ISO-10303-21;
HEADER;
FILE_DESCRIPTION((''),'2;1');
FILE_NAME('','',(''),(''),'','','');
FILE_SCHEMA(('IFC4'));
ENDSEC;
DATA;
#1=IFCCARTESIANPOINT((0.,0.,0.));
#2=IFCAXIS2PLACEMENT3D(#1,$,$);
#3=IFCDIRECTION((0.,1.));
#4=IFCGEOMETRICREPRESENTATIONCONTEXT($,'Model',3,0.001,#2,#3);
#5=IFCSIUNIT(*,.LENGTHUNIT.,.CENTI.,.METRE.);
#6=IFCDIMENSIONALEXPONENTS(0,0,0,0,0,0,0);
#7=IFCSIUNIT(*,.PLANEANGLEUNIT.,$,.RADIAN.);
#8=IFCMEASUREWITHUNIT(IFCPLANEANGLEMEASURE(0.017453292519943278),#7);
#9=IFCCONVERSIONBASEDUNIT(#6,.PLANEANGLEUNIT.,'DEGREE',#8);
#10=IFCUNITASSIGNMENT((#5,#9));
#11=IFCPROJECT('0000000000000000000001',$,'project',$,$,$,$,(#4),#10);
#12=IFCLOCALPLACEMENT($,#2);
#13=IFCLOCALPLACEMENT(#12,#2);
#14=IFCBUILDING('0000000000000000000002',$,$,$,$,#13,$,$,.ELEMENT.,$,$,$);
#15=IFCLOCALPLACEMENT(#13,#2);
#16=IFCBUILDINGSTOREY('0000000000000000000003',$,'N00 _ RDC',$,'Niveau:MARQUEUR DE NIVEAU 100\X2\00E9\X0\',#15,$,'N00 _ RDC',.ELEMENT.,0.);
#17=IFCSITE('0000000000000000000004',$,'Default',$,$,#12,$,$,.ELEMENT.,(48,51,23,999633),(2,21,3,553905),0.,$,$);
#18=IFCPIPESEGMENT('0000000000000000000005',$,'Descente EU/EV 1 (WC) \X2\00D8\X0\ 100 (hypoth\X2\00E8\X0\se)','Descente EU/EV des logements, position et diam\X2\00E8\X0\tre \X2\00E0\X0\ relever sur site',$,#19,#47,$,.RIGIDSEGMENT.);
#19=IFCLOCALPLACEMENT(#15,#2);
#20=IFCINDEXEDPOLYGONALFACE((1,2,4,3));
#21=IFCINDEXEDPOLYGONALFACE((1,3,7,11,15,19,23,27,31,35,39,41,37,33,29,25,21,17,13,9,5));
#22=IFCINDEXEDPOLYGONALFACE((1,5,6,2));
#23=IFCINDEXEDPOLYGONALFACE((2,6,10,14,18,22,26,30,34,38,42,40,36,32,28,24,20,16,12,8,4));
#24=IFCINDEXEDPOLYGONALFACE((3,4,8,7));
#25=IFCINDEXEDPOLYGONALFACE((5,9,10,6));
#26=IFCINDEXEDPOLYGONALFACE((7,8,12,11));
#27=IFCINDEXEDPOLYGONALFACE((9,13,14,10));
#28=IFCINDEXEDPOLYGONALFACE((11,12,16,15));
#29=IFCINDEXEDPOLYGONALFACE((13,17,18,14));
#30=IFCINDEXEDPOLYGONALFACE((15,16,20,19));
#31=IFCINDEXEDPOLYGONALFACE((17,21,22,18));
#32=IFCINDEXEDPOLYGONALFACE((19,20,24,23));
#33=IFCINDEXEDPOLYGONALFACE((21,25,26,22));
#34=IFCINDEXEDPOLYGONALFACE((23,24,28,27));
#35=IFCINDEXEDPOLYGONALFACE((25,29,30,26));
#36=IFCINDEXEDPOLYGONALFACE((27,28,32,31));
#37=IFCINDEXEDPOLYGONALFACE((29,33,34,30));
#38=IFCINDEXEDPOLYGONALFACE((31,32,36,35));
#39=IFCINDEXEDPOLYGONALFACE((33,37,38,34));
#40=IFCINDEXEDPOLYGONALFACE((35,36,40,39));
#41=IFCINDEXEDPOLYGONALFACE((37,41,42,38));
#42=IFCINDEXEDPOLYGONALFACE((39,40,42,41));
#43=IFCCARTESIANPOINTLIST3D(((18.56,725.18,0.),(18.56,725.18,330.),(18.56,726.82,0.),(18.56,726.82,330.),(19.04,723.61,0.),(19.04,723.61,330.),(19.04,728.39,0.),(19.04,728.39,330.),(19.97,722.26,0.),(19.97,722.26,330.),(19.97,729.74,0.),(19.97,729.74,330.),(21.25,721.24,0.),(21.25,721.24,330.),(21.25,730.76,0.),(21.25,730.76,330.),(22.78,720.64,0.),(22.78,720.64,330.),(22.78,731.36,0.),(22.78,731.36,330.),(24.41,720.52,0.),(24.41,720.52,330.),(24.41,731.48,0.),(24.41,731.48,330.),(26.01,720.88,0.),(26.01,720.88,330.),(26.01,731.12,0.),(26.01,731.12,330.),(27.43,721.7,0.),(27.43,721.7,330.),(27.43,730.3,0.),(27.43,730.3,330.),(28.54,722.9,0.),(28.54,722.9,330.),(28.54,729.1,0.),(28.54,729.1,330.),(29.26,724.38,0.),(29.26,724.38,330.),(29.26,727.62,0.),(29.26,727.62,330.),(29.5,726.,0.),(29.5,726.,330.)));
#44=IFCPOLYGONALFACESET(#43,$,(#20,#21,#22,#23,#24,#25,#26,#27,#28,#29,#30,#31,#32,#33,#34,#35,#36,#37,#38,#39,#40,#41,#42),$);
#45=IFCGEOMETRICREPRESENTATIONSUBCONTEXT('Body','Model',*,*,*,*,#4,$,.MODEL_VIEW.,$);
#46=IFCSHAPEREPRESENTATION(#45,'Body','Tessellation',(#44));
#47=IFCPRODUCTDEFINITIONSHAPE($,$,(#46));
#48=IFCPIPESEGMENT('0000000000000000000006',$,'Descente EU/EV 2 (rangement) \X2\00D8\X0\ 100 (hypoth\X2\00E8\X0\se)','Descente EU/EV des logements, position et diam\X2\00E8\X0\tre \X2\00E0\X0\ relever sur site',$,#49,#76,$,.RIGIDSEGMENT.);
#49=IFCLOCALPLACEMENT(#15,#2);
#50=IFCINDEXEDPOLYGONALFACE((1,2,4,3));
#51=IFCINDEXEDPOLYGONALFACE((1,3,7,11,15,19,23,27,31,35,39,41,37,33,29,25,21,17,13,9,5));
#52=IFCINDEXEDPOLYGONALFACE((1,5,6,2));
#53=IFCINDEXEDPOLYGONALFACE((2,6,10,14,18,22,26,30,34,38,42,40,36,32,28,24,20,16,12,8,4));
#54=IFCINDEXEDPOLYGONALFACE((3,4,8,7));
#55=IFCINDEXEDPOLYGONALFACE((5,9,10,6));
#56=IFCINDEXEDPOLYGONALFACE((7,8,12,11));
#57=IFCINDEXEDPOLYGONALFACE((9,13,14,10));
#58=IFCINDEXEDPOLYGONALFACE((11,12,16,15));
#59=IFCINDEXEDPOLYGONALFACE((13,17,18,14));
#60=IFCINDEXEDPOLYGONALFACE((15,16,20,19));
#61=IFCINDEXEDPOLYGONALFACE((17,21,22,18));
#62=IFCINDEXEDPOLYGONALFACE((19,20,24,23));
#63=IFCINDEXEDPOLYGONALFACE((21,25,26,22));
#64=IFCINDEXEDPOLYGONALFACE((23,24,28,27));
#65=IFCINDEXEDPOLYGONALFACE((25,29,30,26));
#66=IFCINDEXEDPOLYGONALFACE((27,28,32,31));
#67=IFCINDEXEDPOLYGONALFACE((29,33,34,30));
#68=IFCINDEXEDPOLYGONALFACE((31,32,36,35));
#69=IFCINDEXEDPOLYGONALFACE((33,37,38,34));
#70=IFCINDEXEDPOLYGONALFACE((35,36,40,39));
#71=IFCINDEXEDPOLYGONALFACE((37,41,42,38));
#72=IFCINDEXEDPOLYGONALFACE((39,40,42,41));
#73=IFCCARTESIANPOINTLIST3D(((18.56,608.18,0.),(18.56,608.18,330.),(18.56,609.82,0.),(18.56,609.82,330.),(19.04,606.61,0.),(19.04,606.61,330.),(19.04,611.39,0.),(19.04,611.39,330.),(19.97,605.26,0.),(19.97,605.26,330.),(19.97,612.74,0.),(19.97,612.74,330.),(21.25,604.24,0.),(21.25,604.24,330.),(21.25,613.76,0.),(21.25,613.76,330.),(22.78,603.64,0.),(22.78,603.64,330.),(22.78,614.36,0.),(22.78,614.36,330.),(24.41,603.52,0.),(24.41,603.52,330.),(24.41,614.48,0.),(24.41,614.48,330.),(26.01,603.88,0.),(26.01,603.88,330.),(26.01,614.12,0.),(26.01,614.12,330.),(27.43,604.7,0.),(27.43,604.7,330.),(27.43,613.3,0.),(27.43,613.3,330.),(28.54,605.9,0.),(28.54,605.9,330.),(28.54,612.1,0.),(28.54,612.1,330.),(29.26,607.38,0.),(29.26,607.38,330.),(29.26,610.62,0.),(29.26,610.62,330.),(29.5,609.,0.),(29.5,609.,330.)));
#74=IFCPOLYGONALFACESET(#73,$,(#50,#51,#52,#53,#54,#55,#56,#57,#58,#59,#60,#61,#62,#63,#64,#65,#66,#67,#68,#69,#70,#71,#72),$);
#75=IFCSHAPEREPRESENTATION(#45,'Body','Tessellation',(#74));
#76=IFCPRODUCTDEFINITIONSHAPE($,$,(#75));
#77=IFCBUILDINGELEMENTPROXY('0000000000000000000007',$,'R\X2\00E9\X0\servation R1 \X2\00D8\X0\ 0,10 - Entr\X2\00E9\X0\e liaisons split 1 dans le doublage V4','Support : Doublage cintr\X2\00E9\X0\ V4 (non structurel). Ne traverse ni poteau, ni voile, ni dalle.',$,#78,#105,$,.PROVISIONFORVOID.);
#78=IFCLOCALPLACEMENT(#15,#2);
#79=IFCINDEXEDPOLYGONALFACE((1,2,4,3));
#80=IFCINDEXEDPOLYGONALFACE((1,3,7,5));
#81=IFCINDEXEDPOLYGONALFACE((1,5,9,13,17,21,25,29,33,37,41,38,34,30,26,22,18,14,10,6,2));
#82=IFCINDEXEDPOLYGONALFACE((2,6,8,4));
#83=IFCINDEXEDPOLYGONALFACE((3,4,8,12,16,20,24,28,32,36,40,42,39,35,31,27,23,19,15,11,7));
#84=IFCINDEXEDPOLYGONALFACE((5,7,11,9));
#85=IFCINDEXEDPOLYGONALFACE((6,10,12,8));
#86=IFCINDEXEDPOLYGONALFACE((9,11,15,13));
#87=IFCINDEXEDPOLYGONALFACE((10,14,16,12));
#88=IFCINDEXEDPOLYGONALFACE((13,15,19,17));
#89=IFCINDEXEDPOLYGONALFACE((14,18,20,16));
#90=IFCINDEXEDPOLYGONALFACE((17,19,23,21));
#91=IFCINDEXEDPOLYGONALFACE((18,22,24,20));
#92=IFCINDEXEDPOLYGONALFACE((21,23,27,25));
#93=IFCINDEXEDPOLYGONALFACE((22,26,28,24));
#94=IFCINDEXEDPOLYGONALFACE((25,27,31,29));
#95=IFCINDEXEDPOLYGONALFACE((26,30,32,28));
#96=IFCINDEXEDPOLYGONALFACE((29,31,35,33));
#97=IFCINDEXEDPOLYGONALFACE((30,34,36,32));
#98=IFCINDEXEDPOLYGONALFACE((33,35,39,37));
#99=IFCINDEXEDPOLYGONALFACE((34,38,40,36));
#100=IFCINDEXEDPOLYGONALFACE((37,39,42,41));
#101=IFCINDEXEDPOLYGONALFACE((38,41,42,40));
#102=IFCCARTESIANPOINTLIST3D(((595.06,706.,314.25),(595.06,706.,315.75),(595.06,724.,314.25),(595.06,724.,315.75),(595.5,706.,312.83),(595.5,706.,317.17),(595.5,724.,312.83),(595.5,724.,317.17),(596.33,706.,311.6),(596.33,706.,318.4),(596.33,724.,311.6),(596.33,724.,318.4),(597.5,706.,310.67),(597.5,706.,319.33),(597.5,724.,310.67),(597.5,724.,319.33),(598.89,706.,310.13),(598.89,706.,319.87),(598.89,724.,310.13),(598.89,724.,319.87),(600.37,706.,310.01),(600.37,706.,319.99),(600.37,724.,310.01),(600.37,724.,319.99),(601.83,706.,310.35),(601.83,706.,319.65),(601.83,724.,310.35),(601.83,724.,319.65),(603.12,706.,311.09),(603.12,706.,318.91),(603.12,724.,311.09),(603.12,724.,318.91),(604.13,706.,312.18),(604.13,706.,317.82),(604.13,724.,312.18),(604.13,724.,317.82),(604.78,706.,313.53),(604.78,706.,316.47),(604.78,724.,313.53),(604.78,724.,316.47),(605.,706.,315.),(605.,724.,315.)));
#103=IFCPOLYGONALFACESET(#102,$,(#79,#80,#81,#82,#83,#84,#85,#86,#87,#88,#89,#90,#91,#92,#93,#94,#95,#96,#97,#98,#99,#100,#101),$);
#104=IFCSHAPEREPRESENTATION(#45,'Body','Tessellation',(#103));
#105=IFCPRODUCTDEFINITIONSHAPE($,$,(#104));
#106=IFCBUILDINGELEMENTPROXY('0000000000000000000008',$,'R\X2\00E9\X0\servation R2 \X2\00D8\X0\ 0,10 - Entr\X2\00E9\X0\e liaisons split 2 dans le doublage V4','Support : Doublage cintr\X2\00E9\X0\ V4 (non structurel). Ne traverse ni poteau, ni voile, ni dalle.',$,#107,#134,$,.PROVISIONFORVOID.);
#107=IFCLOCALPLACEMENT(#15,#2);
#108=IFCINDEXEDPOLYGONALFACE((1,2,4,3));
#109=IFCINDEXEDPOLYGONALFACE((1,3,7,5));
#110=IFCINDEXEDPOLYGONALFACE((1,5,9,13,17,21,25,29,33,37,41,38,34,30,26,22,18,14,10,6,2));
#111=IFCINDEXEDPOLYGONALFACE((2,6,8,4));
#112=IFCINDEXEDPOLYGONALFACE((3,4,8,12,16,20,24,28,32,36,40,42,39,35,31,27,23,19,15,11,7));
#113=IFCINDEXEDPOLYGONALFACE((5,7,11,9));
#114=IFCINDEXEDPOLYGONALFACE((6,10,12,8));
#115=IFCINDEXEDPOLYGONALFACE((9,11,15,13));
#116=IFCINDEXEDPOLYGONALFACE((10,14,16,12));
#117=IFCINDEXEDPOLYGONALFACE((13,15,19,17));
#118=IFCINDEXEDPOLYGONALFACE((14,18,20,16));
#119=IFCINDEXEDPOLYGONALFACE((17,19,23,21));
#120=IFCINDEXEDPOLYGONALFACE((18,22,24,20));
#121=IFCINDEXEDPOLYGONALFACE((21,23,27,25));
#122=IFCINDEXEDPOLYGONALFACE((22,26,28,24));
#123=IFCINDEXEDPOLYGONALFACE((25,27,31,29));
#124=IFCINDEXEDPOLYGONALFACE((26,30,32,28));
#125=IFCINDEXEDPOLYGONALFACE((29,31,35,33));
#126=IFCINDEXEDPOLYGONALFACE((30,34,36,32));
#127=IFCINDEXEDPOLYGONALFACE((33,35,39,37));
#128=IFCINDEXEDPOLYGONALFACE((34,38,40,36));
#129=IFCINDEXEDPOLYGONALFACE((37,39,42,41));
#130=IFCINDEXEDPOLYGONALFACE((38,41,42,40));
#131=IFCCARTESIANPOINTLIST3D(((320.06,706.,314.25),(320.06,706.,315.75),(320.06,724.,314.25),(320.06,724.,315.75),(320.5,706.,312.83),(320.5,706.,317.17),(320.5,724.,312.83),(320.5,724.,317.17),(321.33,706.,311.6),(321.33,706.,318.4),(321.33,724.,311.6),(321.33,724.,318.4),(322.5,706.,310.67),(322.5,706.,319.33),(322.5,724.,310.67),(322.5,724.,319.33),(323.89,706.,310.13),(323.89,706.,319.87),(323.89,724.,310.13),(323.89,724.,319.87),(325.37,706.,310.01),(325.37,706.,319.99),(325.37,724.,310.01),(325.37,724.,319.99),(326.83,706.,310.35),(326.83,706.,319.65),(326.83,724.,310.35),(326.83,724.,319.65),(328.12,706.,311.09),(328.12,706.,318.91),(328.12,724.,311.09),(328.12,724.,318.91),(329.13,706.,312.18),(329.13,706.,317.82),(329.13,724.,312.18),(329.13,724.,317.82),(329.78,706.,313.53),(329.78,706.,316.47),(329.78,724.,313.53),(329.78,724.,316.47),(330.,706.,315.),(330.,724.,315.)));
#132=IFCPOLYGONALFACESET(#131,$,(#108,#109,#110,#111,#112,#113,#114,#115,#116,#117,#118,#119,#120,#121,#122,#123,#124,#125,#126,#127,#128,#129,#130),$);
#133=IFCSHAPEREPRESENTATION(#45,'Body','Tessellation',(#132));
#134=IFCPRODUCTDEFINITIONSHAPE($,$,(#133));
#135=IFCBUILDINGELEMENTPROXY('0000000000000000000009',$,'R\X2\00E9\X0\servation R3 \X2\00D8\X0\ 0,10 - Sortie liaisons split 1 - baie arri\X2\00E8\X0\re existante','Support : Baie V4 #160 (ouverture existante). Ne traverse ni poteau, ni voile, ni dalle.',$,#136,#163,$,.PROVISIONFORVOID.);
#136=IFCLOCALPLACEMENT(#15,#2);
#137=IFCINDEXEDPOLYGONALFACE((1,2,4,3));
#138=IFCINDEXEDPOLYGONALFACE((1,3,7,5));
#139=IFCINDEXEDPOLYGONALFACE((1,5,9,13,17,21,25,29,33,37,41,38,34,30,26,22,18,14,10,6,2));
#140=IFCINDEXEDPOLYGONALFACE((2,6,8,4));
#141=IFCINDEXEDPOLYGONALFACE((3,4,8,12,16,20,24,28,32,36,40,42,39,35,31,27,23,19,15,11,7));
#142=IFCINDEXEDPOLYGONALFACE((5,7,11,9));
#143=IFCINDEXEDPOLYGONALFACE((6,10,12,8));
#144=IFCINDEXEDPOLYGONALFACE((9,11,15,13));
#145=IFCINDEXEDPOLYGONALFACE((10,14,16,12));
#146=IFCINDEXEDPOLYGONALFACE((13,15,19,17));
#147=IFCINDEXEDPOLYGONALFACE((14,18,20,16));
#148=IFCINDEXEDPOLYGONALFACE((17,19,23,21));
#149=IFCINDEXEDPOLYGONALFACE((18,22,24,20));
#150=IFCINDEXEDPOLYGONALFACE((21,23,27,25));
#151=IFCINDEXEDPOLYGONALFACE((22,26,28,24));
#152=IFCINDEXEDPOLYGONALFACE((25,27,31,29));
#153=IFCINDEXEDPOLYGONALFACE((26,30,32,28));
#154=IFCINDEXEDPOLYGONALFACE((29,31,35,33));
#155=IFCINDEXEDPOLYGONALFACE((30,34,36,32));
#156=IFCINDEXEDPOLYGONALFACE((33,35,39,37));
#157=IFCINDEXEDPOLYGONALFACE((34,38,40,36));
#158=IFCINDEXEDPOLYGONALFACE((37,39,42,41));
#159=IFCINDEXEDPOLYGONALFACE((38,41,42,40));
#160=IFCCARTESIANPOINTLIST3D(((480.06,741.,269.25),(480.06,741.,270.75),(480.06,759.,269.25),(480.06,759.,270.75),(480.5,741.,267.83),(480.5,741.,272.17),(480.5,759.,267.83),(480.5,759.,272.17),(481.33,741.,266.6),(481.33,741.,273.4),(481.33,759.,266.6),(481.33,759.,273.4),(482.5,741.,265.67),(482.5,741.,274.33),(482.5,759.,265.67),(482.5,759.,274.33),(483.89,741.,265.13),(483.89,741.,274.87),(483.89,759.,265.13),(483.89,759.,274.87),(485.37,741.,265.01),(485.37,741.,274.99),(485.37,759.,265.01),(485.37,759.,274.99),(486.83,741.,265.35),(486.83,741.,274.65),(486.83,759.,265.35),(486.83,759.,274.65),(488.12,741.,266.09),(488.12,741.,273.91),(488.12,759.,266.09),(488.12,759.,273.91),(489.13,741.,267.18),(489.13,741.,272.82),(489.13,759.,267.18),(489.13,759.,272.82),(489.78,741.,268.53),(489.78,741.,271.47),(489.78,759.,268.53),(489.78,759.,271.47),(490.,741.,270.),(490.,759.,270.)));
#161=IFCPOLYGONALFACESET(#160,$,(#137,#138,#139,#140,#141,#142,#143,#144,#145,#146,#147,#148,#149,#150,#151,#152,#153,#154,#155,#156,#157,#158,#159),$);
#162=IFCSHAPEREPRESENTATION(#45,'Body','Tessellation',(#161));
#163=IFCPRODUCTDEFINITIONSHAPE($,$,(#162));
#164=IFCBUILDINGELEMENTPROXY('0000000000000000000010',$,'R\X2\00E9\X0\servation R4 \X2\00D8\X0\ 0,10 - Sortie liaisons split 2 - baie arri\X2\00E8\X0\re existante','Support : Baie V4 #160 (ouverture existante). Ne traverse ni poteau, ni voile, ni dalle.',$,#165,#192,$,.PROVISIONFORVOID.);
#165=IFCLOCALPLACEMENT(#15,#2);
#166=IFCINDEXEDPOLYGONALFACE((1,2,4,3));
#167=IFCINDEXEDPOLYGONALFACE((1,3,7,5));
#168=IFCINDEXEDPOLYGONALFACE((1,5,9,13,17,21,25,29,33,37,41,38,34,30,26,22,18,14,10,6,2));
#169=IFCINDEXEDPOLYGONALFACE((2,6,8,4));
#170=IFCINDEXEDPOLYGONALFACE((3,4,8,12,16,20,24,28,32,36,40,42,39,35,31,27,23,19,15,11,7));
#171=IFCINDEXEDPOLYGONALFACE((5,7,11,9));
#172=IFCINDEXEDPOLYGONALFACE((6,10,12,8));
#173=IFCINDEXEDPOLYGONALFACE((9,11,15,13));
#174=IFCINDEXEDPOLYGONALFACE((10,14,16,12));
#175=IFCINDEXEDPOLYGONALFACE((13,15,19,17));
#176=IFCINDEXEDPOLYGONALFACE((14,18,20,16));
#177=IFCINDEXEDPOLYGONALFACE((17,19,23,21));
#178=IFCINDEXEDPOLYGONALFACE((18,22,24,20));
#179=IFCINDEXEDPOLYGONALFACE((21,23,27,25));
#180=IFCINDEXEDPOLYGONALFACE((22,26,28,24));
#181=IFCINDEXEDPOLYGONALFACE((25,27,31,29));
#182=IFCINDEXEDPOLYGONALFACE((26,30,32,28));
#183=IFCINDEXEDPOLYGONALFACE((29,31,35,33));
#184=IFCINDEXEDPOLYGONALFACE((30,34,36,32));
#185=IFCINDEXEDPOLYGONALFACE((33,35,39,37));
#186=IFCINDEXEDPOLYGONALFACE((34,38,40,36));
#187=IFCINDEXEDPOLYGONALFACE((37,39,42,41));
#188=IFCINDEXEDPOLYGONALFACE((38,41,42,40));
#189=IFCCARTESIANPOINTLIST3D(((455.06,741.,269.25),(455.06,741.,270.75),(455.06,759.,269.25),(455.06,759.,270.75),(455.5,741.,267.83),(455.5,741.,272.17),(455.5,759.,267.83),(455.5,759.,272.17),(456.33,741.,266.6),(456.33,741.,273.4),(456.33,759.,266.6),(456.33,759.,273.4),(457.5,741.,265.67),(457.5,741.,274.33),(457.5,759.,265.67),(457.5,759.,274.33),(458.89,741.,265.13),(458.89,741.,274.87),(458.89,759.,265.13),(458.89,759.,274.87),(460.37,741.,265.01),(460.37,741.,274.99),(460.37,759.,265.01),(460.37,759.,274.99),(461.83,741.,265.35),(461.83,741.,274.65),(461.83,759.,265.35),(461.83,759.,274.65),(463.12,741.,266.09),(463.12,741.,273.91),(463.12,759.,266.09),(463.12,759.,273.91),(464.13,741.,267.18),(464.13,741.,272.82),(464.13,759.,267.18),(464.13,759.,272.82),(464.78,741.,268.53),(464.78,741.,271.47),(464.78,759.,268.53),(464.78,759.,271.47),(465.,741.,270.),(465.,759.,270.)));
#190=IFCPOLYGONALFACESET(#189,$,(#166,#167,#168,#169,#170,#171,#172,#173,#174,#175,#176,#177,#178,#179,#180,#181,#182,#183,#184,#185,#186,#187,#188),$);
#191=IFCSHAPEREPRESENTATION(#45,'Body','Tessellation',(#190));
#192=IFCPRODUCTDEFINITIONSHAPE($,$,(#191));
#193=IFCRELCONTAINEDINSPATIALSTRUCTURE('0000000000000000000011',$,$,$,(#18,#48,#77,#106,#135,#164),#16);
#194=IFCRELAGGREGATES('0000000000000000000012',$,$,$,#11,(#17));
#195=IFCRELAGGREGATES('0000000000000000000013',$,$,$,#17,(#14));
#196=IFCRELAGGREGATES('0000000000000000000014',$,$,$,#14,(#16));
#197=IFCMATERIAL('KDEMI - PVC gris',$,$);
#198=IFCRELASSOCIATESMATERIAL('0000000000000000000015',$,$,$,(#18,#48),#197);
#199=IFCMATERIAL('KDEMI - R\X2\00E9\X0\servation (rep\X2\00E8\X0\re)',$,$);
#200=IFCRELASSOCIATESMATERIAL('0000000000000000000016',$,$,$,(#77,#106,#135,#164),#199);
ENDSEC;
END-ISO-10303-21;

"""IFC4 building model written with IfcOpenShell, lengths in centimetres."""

from ifc_helpers import new_model, entity, si_unit, converted_unit, direction, frame, frame_2d, origin, origin_with_axes, origin_2d, place, context, subcontext, project, spatial, circle, extrude, material, element, save


model = new_model("IFC4")

# Units and contexts
model_context = context("Model", 3, precision=0.001, world=origin(), true_north=direction((0.0, 1.0)))
body_context = subcontext(model_context, "Body", "Model", "MODEL_VIEW")
ifc_project = project(units=[si_unit("LENGTHUNIT", "METRE", prefix="CENTI"), converted_unit("PLANEANGLEUNIT", "DEGREE", entity("IfcPlaneAngleMeasure", 0.017453292519943278), si_unit("PLANEANGLEUNIT", "RADIAN"), dimensions=[0, 0, 0, 0, 0, 0, 0])], contexts=[model_context])

# Site, building, storey
site_placement = place(None, origin())
site = spatial("IfcSite", under=ifc_project, at=site_placement, Name="Default", CompositionType="ELEMENT", RefLatitude=(48, 51, 23, 999633), RefLongitude=(2, 21, 3, 553905), RefElevation=0.0)
building_placement = place(site_placement, origin())
building = spatial("IfcBuilding", under=site, at=building_placement, CompositionType="ELEMENT")
storey_placement = place(building_placement, origin())
storey = spatial("IfcBuildingStorey", under=building, at=storey_placement, Name="N00 _ RDC", ObjectType="Niveau:MARQUEUR DE NIVEAU 100é", LongName="N00 _ RDC", CompositionType="ELEMENT", Elevation=0.0)

# Shared definitions
ifc_material_1 = material(Name="KDEMI - PVC gris")

# Pipe segments
pipe_segment_1_placement = place(storey_placement, origin_with_axes())
element("IfcPipeSegment", 1, at=pipe_segment_1_placement, inside=storey, material=ifc_material_1, Name="Descente EU/EV 1 (WC) Ø 100 (hypothèse)", Description="Descente EU/EV des logements, position et diamètre à relever sur site", PredefinedType="RIGIDSEGMENT", context=body_context, shape_type="SweptSolid", body=[
    extrude(circle(Radius=5.5, at=frame_2d((24.0, 726.0))), origin(), (0.0, 0.0, 1.0), 330.0),
])
pipe_segment_2_placement = place(storey_placement, origin_with_axes())
element("IfcPipeSegment", 2, at=pipe_segment_2_placement, inside=storey, material=ifc_material_1, Name="Descente EU/EV 2 (rangement) Ø 100 (hypothèse)", Description="Descente EU/EV des logements, position et diamètre à relever sur site", PredefinedType="RIGIDSEGMENT", context=body_context, shape_type="SweptSolid", body=[
    extrude(circle(Radius=5.5, at=frame_2d((24.0, 609.0))), origin(), (0.0, 0.0, 1.0), 330.0),
])

# Building element proxies
ifc_material_2 = material(Name="KDEMI - Réservation (repère)")
proxy_1_placement = place(storey_placement, origin_with_axes())
element("IfcBuildingElementProxy", 3, at=proxy_1_placement, inside=storey, material=ifc_material_2, Name="Réservation R1 Ø 0,10 - Entrée liaisons split 1 dans le doublage V4", Description="Support : Doublage cintré V4 (non structurel). Ne traverse ni poteau, ni voile, ni dalle.", PredefinedType="PROVISIONFORVOID", context=body_context, shape_type="SweptSolid", body=[
    extrude(circle(Radius=5.0, at=origin_2d()), frame((600.0, 706.0, 315.0), z_axis=(0.0, 1.0, 0.0), x_axis=(1.0, 0.0, 0.0)), (0.0, 0.0, 1.0), 18.0),
])
proxy_2_placement = place(storey_placement, origin_with_axes())
element("IfcBuildingElementProxy", 4, at=proxy_2_placement, inside=storey, material=ifc_material_2, Name="Réservation R2 Ø 0,10 - Entrée liaisons split 2 dans le doublage V4", Description="Support : Doublage cintré V4 (non structurel). Ne traverse ni poteau, ni voile, ni dalle.", PredefinedType="PROVISIONFORVOID", context=body_context, shape_type="SweptSolid", body=[
    extrude(circle(Radius=5.0, at=origin_2d()), frame((325.0, 706.0, 315.0), z_axis=(0.0, 1.0, 0.0), x_axis=(1.0, 0.0, 0.0)), (0.0, 0.0, 1.0), 18.0),
])
proxy_3_placement = place(storey_placement, origin_with_axes())
element("IfcBuildingElementProxy", 5, at=proxy_3_placement, inside=storey, material=ifc_material_2, Name="Réservation R3 Ø 0,10 - Sortie liaisons split 1 - baie arrière existante", Description="Support : Baie V4 #160 (ouverture existante). Ne traverse ni poteau, ni voile, ni dalle.", PredefinedType="PROVISIONFORVOID", context=body_context, shape_type="SweptSolid", body=[
    extrude(circle(Radius=5.0, at=origin_2d()), frame((485.0, 741.0, 270.0), z_axis=(0.0, 1.0, 0.0), x_axis=(1.0, 0.0, 0.0)), (0.0, 0.0, 1.0), 18.0),
])
proxy_4_placement = place(storey_placement, origin_with_axes())
element("IfcBuildingElementProxy", 6, at=proxy_4_placement, inside=storey, material=ifc_material_2, Name="Réservation R4 Ø 0,10 - Sortie liaisons split 2 - baie arrière existante", Description="Support : Baie V4 #160 (ouverture existante). Ne traverse ni poteau, ni voile, ni dalle.", PredefinedType="PROVISIONFORVOID", context=body_context, shape_type="SweptSolid", body=[
    extrude(circle(Radius=5.0, at=origin_2d()), frame((460.0, 741.0, 270.0), z_axis=(0.0, 1.0, 0.0), x_axis=(1.0, 0.0, 0.0)), (0.0, 0.0, 1.0), 18.0),
])

save(model, "model.ifc")
